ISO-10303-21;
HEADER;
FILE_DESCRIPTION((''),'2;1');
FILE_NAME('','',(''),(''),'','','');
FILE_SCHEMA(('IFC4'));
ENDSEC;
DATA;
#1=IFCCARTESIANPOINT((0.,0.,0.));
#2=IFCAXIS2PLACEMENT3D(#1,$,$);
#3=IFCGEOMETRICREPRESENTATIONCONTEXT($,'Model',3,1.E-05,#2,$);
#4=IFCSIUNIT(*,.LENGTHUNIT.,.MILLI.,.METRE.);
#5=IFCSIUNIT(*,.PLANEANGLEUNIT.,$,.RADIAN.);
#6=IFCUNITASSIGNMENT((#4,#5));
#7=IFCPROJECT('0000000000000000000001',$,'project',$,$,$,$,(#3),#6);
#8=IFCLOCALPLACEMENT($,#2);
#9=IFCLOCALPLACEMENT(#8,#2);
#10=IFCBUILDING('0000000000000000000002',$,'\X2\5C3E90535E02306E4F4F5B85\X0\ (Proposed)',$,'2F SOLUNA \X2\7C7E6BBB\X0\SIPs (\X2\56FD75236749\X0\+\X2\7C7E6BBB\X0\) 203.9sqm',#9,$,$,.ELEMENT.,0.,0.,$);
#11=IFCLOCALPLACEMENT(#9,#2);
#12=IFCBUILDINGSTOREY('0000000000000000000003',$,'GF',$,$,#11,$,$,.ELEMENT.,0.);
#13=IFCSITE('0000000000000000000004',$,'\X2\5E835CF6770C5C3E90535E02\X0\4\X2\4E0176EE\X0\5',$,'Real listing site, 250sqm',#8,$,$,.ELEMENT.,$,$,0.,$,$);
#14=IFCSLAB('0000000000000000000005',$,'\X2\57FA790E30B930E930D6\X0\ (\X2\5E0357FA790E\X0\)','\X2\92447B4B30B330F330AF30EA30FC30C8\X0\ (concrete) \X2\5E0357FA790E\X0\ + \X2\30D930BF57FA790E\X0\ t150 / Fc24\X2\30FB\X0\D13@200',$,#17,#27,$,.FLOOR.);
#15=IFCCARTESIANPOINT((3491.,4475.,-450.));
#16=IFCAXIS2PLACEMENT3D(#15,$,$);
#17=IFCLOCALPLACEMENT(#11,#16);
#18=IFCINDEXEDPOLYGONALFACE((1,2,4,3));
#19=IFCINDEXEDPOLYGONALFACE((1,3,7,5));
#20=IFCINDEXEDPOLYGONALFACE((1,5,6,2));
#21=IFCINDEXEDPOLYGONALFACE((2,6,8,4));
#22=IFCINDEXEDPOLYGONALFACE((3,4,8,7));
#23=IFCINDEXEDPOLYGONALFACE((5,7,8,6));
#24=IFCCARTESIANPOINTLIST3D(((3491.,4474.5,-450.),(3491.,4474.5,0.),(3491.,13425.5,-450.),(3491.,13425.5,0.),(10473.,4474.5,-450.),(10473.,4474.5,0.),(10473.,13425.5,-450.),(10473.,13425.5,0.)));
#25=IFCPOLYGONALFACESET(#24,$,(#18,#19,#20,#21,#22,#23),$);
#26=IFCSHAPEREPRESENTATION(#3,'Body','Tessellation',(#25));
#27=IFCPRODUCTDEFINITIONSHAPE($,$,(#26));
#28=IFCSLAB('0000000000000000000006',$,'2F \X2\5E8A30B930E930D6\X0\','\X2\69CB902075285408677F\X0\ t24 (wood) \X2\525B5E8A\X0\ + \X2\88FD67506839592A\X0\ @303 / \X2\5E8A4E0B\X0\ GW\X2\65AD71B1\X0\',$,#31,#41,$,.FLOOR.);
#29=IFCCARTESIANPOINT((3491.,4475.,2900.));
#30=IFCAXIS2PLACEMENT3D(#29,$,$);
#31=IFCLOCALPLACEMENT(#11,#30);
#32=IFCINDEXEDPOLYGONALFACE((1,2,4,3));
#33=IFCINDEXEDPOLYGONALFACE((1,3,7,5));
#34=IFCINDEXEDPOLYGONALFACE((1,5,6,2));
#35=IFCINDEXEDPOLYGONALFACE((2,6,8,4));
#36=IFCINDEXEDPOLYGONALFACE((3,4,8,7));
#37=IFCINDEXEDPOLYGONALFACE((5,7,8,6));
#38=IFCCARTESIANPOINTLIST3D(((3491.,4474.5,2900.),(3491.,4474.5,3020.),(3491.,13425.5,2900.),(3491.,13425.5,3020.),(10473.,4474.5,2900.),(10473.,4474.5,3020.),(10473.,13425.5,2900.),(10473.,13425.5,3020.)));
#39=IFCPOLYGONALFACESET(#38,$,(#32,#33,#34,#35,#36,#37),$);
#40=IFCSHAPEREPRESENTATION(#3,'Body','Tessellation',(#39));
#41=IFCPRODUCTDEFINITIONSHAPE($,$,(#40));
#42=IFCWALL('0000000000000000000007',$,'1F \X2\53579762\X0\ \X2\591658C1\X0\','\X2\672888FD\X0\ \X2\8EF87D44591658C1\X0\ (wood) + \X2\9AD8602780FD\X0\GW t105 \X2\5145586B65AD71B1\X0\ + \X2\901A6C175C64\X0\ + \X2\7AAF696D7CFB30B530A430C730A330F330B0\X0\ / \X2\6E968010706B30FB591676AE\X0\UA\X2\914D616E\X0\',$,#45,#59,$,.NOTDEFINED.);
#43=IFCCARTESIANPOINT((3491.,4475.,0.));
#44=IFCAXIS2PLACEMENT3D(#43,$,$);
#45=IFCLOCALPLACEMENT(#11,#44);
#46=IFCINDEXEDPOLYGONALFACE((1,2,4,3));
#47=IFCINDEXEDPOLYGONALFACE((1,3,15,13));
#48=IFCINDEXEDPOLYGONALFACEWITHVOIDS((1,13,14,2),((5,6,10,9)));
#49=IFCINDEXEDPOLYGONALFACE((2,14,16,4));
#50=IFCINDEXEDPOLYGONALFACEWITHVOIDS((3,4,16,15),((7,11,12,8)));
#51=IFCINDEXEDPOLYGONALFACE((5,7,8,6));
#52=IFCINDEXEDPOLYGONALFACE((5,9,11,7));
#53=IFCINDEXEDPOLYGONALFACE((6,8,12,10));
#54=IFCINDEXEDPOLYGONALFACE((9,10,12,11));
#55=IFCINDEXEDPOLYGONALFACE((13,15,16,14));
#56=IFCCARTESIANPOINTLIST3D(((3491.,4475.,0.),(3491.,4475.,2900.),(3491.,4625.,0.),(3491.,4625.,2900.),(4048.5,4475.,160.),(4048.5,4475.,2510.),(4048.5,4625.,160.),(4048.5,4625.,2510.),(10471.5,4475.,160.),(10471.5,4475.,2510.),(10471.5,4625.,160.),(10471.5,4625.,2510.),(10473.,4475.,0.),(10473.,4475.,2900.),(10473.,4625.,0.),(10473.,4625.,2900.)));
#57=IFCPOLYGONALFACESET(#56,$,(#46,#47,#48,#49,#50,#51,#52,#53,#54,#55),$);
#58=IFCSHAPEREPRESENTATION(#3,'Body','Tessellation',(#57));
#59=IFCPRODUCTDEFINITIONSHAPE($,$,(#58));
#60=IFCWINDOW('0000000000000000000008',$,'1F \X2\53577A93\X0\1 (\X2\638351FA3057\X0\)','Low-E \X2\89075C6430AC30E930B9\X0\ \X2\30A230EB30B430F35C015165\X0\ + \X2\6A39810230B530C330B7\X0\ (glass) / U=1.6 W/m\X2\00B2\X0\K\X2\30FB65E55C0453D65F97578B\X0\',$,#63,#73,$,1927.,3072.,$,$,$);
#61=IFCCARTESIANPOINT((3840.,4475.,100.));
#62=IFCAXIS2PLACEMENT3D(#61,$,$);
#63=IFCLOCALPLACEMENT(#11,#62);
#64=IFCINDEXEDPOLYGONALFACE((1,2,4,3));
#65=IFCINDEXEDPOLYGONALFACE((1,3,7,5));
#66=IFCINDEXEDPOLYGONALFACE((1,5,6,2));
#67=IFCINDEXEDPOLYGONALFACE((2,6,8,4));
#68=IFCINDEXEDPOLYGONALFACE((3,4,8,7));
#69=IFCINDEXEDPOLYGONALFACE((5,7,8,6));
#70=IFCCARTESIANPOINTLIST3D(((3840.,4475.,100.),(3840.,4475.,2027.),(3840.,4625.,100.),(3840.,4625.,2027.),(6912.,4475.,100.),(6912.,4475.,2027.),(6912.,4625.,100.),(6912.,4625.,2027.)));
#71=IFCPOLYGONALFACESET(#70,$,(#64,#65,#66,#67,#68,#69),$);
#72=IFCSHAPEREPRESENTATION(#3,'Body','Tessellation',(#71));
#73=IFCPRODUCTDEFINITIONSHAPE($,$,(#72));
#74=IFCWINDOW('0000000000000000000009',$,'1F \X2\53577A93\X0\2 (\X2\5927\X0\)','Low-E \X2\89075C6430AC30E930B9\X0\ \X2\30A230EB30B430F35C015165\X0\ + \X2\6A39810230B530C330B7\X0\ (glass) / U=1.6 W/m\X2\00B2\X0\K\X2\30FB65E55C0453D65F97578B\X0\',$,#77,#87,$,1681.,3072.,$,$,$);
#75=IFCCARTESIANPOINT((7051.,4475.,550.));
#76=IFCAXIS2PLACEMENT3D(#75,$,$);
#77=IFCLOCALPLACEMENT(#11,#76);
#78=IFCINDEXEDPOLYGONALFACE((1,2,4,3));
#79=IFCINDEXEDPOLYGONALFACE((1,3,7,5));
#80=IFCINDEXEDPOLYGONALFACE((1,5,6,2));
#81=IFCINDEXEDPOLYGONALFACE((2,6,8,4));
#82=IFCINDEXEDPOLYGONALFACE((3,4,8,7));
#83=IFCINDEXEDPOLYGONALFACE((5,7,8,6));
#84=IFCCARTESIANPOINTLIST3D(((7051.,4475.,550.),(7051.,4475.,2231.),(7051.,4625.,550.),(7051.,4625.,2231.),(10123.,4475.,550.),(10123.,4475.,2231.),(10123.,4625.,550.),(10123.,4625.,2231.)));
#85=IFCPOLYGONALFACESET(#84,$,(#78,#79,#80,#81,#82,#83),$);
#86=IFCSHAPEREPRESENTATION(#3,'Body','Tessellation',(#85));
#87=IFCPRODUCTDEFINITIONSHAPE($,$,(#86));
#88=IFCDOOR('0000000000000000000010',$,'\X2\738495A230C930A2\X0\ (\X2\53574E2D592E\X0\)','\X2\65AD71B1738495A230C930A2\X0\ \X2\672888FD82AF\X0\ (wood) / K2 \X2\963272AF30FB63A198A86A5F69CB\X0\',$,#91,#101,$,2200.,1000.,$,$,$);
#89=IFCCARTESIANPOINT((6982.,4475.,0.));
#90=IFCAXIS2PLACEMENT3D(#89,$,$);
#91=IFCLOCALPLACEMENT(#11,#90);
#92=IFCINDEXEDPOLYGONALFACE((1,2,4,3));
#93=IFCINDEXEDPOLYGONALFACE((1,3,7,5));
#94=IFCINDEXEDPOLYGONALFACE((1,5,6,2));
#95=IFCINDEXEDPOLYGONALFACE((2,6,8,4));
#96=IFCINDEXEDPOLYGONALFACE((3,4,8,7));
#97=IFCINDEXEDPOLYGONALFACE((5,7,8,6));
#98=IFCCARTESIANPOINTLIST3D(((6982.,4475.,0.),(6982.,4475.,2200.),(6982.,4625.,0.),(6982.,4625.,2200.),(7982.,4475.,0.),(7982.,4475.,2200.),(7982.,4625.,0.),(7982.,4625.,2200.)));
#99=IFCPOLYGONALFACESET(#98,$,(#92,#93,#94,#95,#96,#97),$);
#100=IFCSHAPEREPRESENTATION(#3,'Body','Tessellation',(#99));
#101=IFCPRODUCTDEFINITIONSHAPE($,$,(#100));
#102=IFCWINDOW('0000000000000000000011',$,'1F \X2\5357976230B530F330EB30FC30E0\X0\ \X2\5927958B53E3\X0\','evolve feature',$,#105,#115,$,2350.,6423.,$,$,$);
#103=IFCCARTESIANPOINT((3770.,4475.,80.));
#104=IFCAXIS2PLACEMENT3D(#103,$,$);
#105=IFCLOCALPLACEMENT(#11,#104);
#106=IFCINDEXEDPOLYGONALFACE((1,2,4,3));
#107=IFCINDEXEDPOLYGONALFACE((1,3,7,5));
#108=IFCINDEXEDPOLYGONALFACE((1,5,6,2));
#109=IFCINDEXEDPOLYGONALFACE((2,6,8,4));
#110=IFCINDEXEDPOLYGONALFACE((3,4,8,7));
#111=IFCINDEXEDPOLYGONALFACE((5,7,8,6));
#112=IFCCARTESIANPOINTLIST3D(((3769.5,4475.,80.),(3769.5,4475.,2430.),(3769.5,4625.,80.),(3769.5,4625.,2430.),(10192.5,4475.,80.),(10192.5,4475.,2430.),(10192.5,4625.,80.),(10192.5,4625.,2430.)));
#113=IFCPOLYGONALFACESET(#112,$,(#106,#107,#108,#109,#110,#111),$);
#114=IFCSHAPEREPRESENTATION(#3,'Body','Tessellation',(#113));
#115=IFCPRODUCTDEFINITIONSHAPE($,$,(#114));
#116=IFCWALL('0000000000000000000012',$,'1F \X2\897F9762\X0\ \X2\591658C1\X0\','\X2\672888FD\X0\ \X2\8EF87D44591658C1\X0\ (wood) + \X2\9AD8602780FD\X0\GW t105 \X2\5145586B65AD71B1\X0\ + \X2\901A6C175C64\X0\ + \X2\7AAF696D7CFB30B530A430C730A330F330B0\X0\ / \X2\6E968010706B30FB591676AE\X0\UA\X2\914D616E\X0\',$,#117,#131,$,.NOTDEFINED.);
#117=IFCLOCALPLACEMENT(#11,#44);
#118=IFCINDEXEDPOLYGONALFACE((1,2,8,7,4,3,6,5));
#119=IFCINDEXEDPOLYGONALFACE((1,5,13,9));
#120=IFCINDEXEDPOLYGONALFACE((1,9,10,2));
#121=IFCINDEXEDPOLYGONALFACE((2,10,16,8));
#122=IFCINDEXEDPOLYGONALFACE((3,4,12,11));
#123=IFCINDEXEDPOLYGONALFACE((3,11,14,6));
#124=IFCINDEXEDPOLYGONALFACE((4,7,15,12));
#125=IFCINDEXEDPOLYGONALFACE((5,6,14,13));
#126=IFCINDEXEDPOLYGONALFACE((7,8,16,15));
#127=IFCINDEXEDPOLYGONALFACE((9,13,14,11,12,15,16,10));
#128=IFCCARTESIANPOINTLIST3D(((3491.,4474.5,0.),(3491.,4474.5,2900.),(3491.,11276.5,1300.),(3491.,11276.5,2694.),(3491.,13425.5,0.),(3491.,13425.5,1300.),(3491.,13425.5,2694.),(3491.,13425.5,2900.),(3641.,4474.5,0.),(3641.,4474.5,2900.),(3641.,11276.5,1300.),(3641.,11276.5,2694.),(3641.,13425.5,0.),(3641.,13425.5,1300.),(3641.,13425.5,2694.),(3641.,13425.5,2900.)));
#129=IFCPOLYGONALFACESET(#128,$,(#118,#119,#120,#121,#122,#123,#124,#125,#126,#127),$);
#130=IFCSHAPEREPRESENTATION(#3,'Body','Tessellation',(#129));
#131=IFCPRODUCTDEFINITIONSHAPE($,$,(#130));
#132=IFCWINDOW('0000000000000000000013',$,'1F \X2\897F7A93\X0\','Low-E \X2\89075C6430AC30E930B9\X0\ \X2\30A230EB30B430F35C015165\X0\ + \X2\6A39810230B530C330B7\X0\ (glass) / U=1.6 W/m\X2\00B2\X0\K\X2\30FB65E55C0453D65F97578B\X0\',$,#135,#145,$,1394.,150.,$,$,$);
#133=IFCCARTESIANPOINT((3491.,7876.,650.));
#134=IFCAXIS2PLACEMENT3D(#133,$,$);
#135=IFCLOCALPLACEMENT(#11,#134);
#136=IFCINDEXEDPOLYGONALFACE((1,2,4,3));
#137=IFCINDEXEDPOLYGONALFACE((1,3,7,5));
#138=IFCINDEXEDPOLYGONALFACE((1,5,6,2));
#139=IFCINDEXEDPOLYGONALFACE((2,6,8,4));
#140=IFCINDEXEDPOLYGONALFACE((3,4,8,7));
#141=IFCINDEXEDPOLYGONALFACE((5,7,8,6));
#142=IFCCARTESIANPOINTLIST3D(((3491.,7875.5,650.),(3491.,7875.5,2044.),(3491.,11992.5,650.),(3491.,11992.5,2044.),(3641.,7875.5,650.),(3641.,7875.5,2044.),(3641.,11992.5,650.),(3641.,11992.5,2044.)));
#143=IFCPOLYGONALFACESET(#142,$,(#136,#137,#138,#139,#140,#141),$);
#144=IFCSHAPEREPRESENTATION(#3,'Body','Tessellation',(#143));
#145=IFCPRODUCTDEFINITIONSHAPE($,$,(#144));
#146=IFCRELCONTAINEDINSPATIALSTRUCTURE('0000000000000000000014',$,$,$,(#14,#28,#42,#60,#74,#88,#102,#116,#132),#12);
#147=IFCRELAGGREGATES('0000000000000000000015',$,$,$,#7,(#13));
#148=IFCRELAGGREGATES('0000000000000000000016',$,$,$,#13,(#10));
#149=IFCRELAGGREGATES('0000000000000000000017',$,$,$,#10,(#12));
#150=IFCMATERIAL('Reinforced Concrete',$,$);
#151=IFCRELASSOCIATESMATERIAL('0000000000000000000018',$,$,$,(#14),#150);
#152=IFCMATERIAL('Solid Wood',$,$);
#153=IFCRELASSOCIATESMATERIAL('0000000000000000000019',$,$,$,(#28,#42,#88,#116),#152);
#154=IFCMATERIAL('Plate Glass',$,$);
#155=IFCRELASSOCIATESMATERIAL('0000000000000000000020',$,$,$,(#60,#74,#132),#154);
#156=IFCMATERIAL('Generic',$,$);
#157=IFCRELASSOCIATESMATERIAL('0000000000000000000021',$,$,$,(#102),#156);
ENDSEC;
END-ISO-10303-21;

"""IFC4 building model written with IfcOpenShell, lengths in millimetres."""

from ifc_helpers import new_model, si_unit, frame, frame_2d, origin, place, context, project, spatial, rectangle, extrude, material, element, fill, save


model = new_model("IFC4")

# Units and contexts
model_context = context("Model", 3, precision=1e-05, world=origin())
ifc_project = project(units=[si_unit("LENGTHUNIT", "METRE", prefix="MILLI"), si_unit("PLANEANGLEUNIT", "RADIAN")], contexts=[model_context])

# Site, building, storey
site_placement = place(None, origin())
site = spatial("IfcSite", under=ifc_project, at=site_placement, Name="広島県尾道市4丁目5", ObjectType="Real listing site, 250sqm", CompositionType="ELEMENT", RefElevation=0.0)
building_placement = place(site_placement, origin())
building = spatial("IfcBuilding", under=site, at=building_placement, Name="尾道市の住宅 (Proposed)", ObjectType="2F SOLUNA 籾殻SIPs (国産杉+籾殻) 203.9sqm", CompositionType="ELEMENT", ElevationOfRefHeight=0.0, ElevationOfTerrain=0.0)
storey_placement = place(building_placement, origin())
storey = spatial("IfcBuildingStorey", under=building, at=storey_placement, Name="GF", CompositionType="ELEMENT", Elevation=0.0)

# Slabs
ifc_material_1 = material(Name="Reinforced Concrete")
slab_1_placement = place(storey_placement, frame((3491.0, 4475.0, -450.0)))
element("IfcSlab", 1, at=slab_1_placement, inside=storey, material=ifc_material_1, Name="基礎スラブ (布基礎)", Description="鉄筋コンクリート (concrete) 布基礎 + ベタ基礎 t150 / Fc24・D13@200", PredefinedType="FLOOR", context=model_context, shape_type="SweptSolid", body=[
    extrude(rectangle(XDim=6982.0, YDim=8951.0, at=frame_2d((3491.0, 4475.0))), frame((3491.0, 4475.0, -450.0)), (0.0, 0.0, 1.0), 450.0),
])
ifc_material_2 = material(Name="Solid Wood")
slab_2_placement = place(storey_placement, frame((3491.0, 4475.0, 2900.0)))
element("IfcSlab", 2, at=slab_2_placement, inside=storey, material=ifc_material_2, Name="2F 床スラブ", Description="構造用合板 t24 (wood) 剛床 + 製材根太 @303 / 床下 GW断熱", PredefinedType="FLOOR", context=model_context, shape_type="SweptSolid", body=[
    extrude(rectangle(XDim=6982.0, YDim=8951.0, at=frame_2d((3491.0, 4475.0))), frame((3491.0, 4475.0, 2900.0)), (0.0, 0.0, 1.0), 120.0),
])

# Wall, openings, windows, door
wall_1_placement = place(storey_placement, frame((3491.0, 4475.0, 0.0)))
wall_1 = element("IfcWall", 3, at=wall_1_placement, inside=storey, material=ifc_material_2, Name="1F 南面 外壁", Description="木製 軸組外壁 (wood) + 高性能GW t105 充填断熱 + 通気層 + 窯業系サイディング / 準耐火・外皮UA配慮", PredefinedType="NOTDEFINED", context=model_context, shape_type="SweptSolid", body=[
    extrude(rectangle(XDim=6982.0, YDim=150.0, at=frame_2d((3491.0, 75.0))), frame((3491.0, 4475.0, 0.0)), (0.0, 0.0, 1.0), 2900.0),
])
opening_1_placement = place(storey_placement, frame((3840.0, 4475.0, 100.0)))
opening_1 = element("IfcOpeningElement", 4, at=opening_1_placement, cuts=wall_1, PredefinedType="NOTDEFINED", context=model_context, shape_type="SweptSolid", body=[
    extrude(rectangle(XDim=3072.0, YDim=150.0, at=frame_2d((1536.0, 75.0))), frame((3840.0, 4475.0, 100.0)), (0.0, 0.0, 1.0), 1927.0),
])
opening_2_placement = place(storey_placement, frame((7051.0, 4475.0, 550.0)))
opening_2 = element("IfcOpeningElement", 5, at=opening_2_placement, cuts=wall_1, PredefinedType="NOTDEFINED", context=model_context, shape_type="SweptSolid", body=[
    extrude(rectangle(XDim=3072.0, YDim=150.0, at=frame_2d((1536.0, 75.0))), frame((7051.0, 4475.0, 550.0)), (0.0, 0.0, 1.0), 1681.0),
])
opening_3_placement = place(storey_placement, frame((6982.0, 4475.0, 0.0)))
opening_3 = element("IfcOpeningElement", 6, at=opening_3_placement, cuts=wall_1, PredefinedType="NOTDEFINED", context=model_context, shape_type="SweptSolid", body=[
    extrude(rectangle(XDim=1000.0, YDim=150.0, at=frame_2d((500.0, 75.0))), frame((6982.0, 4475.0, 0.0)), (0.0, 0.0, 1.0), 2200.0),
])
opening_4_placement = place(storey_placement, frame((3770.0, 4475.0, 80.0)))
opening_4 = element("IfcOpeningElement", 7, at=opening_4_placement, cuts=wall_1, PredefinedType="NOTDEFINED", context=model_context, shape_type="SweptSolid", body=[
    extrude(rectangle(XDim=6423.0, YDim=150.0, at=frame_2d((3211.0, 75.0))), frame((3770.0, 4475.0, 80.0)), (0.0, 0.0, 1.0), 2350.0),
])
ifc_material_3 = material(Name="Plate Glass")
window_1_placement = place(storey_placement, frame((3840.0, 4475.0, 100.0)))
window_1 = element("IfcWindow", 8, at=window_1_placement, inside=storey, material=ifc_material_3, Name="1F 南窓1 (掃出し)", Description="Low-E 複層ガラス アルゴン封入 + 樹脂サッシ (glass) / U=1.6 W/m²K・日射取得型", OverallHeight=1927.0, OverallWidth=3072.0, context=model_context, shape_type="SweptSolid", body=[
    extrude(rectangle(XDim=3072.0, YDim=150.0, at=frame_2d((1536.0, 75.0))), frame((3840.0, 4475.0, 100.0)), (0.0, 0.0, 1.0), 1927.0),
])
fill(opening_1, window_1)
window_2_placement = place(storey_placement, frame((7051.0, 4475.0, 550.0)))
window_2 = element("IfcWindow", 9, at=window_2_placement, inside=storey, material=ifc_material_3, Name="1F 南窓2 (大)", Description="Low-E 複層ガラス アルゴン封入 + 樹脂サッシ (glass) / U=1.6 W/m²K・日射取得型", OverallHeight=1681.0, OverallWidth=3072.0, context=model_context, shape_type="SweptSolid", body=[
    extrude(rectangle(XDim=3072.0, YDim=150.0, at=frame_2d((1536.0, 75.0))), frame((7051.0, 4475.0, 550.0)), (0.0, 0.0, 1.0), 1681.0),
])
fill(opening_2, window_2)
door_placement = place(storey_placement, frame((6982.0, 4475.0, 0.0)))
door = element("IfcDoor", 10, at=door_placement, inside=storey, material=ifc_material_2, Name="玄関ドア (南中央)", Description="断熱玄関ドア 木製芯 (wood) / K2 防犯・採風機構", OverallHeight=2200.0, OverallWidth=1000.0, context=model_context, shape_type="SweptSolid", body=[
    extrude(rectangle(XDim=1000.0, YDim=150.0, at=frame_2d((500.0, 75.0))), frame((6982.0, 4475.0, 0.0)), (0.0, 0.0, 1.0), 2200.0),
])
fill(opening_3, door)
ifc_material_4 = material(Name="Generic")
window_3_placement = place(storey_placement, frame((3770.0, 4475.0, 80.0)))
window_3 = element("IfcWindow", 11, at=window_3_placement, inside=storey, material=ifc_material_4, Name="1F 南面サンルーム 大開口", Description="evolve feature", OverallHeight=2350.0, OverallWidth=6423.0, context=model_context, shape_type="SweptSolid", body=[
    extrude(rectangle(XDim=6423.0, YDim=150.0, at=frame_2d((3211.0, 75.0))), frame((3770.0, 4475.0, 80.0)), (0.0, 0.0, 1.0), 2350.0),
])
fill(opening_4, window_3)

# Wall, opening, window
wall_2_placement = place(storey_placement, frame((3491.0, 4475.0, 0.0)))
wall_2 = element("IfcWall", 12, at=wall_2_placement, inside=storey, material=ifc_material_2, Name="1F 西面 外壁", Description="木製 軸組外壁 (wood) + 高性能GW t105 充填断熱 + 通気層 + 窯業系サイディング / 準耐火・外皮UA配慮", PredefinedType="NOTDEFINED", context=model_context, shape_type="SweptSolid", body=[
    extrude(rectangle(XDim=150.0, YDim=8951.0, at=frame_2d((75.0, 4475.0))), frame((3491.0, 4475.0, 0.0)), (0.0, 0.0, 1.0), 2900.0),
])
opening_5_placement = place(storey_placement, frame((3491.0, 7876.0, 650.0)))
opening_5 = element("IfcOpeningElement", 13, at=opening_5_placement, cuts=wall_2, PredefinedType="NOTDEFINED", context=model_context, shape_type="SweptSolid", body=[
    extrude(rectangle(XDim=150.0, YDim=4117.0, at=frame_2d((75.0, 2058.0))), frame((3491.0, 7876.0, 650.0)), (0.0, 0.0, 1.0), 1394.0),
])
window_4_placement = place(storey_placement, frame((3491.0, 7876.0, 650.0)))
window_4 = element("IfcWindow", 14, at=window_4_placement, inside=storey, material=ifc_material_3, Name="1F 西窓", Description="Low-E 複層ガラス アルゴン封入 + 樹脂サッシ (glass) / U=1.6 W/m²K・日射取得型", OverallHeight=1394.0, OverallWidth=150.0, context=model_context, shape_type="SweptSolid", body=[
    extrude(rectangle(XDim=150.0, YDim=4117.0, at=frame_2d((75.0, 2058.0))), frame((3491.0, 7876.0, 650.0)), (0.0, 0.0, 1.0), 1394.0),
])
fill(opening_5, window_4)

save(model, "model.ifc")
